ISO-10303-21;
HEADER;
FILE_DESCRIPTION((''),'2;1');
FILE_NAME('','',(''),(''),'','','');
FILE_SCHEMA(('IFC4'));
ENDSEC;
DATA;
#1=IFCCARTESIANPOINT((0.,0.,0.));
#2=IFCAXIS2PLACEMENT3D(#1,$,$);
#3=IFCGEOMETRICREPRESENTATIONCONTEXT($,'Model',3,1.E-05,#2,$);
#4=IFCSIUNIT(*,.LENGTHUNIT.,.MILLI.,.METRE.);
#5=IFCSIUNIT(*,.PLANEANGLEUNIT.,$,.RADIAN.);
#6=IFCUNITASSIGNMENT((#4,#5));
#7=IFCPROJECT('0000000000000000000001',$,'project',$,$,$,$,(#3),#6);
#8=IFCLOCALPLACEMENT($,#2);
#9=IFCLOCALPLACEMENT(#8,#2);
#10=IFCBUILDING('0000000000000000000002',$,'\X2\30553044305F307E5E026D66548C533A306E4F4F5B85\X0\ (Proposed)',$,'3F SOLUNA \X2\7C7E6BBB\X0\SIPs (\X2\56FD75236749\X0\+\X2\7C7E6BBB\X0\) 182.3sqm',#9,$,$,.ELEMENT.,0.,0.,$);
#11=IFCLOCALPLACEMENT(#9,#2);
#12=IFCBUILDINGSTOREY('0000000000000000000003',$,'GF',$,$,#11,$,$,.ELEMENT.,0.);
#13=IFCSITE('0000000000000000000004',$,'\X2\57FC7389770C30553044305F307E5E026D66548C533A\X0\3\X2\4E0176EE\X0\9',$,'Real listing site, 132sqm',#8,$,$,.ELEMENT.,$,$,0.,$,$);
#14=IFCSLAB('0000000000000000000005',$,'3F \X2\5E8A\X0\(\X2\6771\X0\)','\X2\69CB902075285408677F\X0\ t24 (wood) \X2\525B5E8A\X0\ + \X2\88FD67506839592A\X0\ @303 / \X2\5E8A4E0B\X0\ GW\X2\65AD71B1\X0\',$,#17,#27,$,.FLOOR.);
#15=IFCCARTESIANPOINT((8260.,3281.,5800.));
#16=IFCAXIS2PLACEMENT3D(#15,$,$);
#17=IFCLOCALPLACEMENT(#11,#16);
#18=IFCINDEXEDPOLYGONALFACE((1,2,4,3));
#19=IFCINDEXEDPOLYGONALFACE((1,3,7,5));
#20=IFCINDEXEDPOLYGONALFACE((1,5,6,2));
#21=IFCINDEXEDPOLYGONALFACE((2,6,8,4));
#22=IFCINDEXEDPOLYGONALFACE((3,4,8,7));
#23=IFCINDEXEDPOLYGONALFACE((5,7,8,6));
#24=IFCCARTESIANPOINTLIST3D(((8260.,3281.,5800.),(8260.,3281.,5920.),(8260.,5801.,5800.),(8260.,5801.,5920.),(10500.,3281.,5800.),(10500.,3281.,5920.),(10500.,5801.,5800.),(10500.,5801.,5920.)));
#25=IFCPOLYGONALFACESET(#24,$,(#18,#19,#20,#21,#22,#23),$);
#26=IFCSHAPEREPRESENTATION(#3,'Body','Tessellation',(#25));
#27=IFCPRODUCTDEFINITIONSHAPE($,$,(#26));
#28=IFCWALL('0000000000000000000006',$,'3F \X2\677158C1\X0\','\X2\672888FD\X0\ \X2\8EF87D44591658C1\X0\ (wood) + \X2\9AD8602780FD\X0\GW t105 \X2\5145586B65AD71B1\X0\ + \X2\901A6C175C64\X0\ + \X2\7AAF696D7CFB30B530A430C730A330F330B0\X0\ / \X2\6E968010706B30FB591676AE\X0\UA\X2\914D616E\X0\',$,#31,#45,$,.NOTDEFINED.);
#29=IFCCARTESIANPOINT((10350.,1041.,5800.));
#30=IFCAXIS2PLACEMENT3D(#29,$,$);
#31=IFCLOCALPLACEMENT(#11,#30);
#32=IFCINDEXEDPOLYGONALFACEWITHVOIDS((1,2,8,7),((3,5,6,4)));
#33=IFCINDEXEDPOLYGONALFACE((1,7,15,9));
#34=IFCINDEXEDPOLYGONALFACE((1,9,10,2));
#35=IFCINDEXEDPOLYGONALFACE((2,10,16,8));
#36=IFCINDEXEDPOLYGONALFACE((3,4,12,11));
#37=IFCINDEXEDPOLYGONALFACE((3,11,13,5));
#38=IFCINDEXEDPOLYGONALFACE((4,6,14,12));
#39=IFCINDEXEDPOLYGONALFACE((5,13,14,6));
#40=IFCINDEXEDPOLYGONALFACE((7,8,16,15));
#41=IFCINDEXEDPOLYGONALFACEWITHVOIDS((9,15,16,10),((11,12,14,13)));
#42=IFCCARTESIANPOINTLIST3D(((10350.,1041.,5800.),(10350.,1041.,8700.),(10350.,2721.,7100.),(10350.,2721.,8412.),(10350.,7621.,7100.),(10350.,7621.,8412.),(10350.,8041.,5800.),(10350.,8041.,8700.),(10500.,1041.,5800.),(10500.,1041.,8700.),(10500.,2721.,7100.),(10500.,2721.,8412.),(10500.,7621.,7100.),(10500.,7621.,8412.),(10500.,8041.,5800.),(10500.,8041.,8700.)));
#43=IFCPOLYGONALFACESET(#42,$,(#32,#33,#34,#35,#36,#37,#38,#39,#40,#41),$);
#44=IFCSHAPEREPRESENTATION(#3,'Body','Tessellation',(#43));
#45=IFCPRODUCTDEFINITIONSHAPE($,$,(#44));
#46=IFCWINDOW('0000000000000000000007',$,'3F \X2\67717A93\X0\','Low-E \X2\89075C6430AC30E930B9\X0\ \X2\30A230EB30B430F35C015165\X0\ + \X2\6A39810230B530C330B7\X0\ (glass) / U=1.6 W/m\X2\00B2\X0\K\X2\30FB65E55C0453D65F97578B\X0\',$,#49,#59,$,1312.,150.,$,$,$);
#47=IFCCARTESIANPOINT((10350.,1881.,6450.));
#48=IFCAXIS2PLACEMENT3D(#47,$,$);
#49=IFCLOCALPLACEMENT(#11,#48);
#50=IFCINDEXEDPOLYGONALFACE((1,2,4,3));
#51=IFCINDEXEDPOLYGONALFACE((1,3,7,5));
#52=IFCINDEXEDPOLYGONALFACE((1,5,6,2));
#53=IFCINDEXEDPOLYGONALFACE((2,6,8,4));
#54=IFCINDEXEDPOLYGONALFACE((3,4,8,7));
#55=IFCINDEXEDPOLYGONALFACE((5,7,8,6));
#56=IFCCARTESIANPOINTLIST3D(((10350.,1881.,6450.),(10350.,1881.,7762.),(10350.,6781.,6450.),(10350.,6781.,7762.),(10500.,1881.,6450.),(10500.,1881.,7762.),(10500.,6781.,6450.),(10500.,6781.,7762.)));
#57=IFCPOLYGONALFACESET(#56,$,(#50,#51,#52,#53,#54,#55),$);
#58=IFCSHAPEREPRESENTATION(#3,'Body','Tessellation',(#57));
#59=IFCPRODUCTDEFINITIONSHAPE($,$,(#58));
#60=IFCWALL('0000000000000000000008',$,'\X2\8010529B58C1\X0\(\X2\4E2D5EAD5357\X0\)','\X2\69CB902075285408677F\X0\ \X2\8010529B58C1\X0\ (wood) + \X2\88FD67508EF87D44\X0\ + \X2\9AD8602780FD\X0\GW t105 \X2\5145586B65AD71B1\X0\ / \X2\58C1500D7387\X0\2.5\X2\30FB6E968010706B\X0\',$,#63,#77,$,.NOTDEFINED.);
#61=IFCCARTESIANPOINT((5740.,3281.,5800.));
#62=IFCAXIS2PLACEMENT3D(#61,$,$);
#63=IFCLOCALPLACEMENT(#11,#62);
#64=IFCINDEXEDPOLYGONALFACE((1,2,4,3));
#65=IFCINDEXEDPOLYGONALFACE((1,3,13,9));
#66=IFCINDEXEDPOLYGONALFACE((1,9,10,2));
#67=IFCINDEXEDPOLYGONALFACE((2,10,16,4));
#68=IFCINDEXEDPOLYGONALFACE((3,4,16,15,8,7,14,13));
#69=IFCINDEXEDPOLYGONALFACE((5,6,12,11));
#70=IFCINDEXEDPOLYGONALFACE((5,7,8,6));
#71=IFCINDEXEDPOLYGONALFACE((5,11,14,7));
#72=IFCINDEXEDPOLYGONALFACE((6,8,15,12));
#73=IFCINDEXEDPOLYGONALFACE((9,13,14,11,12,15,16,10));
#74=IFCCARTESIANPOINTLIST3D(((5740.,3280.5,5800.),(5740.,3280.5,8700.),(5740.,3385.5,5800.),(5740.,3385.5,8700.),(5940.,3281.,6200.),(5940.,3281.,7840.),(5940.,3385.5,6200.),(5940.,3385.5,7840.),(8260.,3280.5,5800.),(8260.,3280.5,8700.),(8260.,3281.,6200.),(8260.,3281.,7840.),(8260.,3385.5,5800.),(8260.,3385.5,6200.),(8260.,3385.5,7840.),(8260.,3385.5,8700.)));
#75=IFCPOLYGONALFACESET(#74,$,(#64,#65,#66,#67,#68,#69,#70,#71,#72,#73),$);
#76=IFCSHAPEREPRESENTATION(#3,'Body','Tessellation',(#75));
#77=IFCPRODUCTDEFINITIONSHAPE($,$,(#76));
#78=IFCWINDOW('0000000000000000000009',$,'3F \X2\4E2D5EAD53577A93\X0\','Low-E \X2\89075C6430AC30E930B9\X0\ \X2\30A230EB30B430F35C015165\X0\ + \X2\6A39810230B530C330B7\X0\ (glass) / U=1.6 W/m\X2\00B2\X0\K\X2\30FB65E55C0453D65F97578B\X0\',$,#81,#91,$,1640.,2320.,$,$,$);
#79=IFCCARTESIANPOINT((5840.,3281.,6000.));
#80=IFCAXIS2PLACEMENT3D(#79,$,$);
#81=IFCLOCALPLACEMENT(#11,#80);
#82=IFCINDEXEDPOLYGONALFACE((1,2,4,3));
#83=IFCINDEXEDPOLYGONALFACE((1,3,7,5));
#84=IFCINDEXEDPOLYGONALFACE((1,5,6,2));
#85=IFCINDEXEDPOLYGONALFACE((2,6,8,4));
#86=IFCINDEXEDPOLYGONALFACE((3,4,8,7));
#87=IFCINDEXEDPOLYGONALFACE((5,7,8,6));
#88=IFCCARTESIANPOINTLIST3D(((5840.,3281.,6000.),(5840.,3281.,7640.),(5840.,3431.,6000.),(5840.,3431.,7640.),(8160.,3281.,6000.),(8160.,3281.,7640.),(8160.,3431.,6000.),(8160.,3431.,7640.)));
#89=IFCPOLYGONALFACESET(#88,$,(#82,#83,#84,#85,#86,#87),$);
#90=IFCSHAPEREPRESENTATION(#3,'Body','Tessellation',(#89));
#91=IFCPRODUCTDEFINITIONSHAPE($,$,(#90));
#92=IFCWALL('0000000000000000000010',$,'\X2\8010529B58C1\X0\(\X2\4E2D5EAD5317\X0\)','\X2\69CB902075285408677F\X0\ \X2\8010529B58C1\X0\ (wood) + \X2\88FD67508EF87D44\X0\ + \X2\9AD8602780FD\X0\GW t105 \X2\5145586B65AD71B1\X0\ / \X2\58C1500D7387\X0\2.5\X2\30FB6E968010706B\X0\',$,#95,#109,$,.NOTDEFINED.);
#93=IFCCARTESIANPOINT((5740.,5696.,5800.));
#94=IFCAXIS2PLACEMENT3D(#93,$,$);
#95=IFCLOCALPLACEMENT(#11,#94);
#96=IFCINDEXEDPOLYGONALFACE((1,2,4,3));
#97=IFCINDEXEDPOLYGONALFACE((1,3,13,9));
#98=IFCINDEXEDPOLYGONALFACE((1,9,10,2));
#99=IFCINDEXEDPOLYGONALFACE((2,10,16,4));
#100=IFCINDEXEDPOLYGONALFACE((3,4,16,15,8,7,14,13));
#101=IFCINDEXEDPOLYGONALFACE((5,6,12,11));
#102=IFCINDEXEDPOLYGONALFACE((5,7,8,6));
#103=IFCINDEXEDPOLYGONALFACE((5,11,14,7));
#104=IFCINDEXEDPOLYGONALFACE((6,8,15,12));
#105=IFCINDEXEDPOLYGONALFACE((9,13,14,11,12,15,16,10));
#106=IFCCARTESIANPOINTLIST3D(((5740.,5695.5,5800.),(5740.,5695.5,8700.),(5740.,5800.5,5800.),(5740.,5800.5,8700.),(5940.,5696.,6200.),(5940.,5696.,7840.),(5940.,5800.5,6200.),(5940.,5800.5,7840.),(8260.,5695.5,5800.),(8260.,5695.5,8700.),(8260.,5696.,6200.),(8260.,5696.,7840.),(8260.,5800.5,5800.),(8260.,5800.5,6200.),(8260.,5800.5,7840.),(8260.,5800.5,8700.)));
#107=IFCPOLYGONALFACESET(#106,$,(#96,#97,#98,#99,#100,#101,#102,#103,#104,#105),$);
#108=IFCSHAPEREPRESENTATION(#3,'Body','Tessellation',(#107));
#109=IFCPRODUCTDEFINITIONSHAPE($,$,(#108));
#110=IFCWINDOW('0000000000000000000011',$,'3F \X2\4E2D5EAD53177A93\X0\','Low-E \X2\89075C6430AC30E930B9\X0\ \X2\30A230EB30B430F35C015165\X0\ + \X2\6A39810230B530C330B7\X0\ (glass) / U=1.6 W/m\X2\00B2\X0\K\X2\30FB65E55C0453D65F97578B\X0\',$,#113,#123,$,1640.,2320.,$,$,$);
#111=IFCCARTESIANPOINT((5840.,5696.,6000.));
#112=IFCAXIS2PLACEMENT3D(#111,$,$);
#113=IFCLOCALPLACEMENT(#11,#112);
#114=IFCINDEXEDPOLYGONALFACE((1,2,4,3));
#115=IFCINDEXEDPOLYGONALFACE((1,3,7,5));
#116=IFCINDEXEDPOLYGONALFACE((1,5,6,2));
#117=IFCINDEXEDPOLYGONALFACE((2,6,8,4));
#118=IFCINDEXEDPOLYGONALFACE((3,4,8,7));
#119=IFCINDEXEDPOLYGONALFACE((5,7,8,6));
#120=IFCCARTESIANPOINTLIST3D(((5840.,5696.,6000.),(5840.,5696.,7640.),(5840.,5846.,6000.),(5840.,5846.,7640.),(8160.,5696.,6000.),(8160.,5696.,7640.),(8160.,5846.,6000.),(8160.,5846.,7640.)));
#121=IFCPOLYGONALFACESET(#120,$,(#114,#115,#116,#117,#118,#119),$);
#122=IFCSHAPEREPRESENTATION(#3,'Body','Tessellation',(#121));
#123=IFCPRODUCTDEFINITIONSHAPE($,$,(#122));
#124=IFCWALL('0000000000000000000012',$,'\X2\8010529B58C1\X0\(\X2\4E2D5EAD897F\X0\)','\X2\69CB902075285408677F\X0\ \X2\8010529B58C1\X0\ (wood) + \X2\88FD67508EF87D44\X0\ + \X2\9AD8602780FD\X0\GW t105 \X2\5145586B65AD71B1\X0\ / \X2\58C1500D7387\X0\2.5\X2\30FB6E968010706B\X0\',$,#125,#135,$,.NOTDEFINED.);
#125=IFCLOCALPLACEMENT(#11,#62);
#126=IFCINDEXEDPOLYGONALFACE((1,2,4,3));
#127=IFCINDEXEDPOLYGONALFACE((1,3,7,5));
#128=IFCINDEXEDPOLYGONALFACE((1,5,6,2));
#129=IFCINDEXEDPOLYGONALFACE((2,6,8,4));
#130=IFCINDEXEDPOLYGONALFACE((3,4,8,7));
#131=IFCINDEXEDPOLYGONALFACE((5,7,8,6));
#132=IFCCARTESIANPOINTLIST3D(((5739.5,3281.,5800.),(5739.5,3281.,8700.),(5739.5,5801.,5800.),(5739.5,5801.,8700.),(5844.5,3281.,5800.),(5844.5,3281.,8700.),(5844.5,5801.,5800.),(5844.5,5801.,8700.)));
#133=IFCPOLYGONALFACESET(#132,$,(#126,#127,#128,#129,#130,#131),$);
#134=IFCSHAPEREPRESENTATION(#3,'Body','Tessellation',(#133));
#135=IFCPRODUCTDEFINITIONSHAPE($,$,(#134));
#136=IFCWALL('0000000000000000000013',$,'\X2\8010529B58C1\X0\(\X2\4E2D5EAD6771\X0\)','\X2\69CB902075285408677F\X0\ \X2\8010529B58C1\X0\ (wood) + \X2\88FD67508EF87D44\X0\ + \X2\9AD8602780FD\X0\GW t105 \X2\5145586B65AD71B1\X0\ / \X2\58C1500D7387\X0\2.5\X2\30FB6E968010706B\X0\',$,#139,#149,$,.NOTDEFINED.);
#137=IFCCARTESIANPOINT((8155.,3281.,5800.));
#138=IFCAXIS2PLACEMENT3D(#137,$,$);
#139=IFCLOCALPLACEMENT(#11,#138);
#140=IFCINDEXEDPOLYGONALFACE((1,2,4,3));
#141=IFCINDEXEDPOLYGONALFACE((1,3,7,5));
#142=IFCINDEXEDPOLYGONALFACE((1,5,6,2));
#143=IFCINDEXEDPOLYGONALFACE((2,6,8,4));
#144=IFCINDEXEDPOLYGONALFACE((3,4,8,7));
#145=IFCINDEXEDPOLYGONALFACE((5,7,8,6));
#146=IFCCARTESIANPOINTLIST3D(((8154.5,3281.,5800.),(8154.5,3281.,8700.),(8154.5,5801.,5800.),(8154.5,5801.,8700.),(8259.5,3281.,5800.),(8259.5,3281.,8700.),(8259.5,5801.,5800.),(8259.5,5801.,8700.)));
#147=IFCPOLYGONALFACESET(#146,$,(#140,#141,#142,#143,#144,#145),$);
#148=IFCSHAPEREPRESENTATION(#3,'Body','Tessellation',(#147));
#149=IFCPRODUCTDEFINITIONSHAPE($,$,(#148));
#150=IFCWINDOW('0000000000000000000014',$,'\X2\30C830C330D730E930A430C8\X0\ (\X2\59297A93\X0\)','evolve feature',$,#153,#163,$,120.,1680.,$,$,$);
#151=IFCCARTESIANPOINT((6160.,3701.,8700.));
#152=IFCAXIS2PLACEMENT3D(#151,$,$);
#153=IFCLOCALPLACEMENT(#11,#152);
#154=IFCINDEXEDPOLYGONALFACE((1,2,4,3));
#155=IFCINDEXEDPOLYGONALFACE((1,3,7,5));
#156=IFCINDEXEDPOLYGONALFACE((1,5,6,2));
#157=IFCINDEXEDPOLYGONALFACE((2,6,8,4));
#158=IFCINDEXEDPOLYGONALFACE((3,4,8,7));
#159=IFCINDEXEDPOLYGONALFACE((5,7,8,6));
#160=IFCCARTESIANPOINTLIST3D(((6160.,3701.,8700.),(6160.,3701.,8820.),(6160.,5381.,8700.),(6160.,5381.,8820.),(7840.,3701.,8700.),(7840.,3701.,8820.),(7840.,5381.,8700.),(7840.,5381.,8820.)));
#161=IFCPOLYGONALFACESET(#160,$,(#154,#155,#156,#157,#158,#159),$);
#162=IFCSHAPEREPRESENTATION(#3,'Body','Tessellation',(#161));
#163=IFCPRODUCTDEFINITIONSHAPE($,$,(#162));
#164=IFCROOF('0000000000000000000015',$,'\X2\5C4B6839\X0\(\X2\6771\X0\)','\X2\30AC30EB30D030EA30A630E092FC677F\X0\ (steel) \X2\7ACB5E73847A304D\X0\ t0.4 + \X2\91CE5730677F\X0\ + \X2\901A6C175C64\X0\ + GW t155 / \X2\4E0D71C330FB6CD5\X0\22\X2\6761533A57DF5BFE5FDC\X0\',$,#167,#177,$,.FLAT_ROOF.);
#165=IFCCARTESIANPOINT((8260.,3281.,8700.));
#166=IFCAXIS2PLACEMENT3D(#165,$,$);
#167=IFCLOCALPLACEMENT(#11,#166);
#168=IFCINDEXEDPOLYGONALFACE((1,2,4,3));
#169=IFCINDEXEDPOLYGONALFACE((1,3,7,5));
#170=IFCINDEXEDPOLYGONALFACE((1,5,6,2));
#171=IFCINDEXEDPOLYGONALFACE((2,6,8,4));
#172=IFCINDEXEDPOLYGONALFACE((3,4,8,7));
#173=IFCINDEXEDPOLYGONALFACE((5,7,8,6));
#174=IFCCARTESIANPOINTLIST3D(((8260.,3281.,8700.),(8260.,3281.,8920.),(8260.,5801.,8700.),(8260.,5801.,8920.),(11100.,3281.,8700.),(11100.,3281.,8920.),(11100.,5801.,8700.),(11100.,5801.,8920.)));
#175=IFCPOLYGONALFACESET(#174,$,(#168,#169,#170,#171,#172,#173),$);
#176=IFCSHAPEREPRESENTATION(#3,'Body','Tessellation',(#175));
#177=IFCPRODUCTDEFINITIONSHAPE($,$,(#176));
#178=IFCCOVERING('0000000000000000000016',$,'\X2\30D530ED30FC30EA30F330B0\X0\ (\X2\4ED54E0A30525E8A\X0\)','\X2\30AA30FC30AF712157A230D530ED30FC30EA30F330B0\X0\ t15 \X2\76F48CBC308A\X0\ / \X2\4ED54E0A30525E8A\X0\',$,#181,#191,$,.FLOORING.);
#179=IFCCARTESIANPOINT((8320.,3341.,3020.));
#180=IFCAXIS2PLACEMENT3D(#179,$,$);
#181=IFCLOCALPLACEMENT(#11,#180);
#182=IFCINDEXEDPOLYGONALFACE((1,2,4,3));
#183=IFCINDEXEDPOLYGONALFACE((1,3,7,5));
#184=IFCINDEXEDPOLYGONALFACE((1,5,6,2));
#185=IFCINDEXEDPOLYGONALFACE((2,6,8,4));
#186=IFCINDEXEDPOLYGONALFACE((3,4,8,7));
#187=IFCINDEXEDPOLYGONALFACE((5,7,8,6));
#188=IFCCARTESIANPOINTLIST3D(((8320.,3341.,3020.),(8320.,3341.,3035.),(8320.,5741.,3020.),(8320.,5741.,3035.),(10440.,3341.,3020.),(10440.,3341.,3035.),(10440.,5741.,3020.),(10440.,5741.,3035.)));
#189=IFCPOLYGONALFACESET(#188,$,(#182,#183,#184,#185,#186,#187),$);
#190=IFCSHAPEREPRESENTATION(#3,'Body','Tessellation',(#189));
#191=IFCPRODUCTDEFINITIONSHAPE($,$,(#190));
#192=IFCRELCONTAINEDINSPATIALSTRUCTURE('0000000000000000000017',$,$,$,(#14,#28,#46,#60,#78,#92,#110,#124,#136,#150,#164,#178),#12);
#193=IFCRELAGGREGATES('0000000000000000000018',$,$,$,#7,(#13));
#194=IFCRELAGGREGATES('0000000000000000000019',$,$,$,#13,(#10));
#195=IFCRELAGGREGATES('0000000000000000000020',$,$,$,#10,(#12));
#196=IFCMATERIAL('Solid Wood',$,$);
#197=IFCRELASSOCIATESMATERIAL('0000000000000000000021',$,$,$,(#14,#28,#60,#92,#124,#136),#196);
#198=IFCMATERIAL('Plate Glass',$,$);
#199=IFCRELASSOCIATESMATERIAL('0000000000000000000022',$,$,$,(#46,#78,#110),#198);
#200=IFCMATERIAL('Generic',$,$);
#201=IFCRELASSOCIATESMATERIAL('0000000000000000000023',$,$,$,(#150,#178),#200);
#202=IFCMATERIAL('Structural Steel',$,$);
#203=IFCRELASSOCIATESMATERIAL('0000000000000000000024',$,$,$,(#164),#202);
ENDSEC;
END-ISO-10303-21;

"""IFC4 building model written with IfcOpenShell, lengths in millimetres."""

from ifc_helpers import new_model, si_unit, frame, frame_2d, origin, place, context, project, spatial, rectangle, extrude, material, element, fill, save


model = new_model("IFC4")

# Units and contexts
model_context = context("Model", 3, precision=1e-05, world=origin())
ifc_project = project(units=[si_unit("LENGTHUNIT", "METRE", prefix="MILLI"), si_unit("PLANEANGLEUNIT", "RADIAN")], contexts=[model_context])

# Site, building, storey
site_placement = place(None, origin())
site = spatial("IfcSite", under=ifc_project, at=site_placement, Name="埼玉県さいたま市浦和区3丁目9", ObjectType="Real listing site, 132sqm", CompositionType="ELEMENT", RefElevation=0.0)
building_placement = place(site_placement, origin())
building = spatial("IfcBuilding", under=site, at=building_placement, Name="さいたま市浦和区の住宅 (Proposed)", ObjectType="3F SOLUNA 籾殻SIPs (国産杉+籾殻) 182.3sqm", CompositionType="ELEMENT", ElevationOfRefHeight=0.0, ElevationOfTerrain=0.0)
storey_placement = place(building_placement, origin())
storey = spatial("IfcBuildingStorey", under=building, at=storey_placement, Name="GF", CompositionType="ELEMENT", Elevation=0.0)

# Slab
ifc_material_1 = material(Name="Solid Wood")
slab_placement = place(storey_placement, frame((8260.0, 3281.0, 5800.0)))
element("IfcSlab", 1, at=slab_placement, inside=storey, material=ifc_material_1, Name="3F 床(東)", Description="構造用合板 t24 (wood) 剛床 + 製材根太 @303 / 床下 GW断熱", PredefinedType="FLOOR", context=model_context, shape_type="SweptSolid", body=[
    extrude(rectangle(XDim=2240.0, YDim=2520.0, at=frame_2d((1120.0, 1260.0))), frame((8260.0, 3281.0, 5800.0)), (0.0, 0.0, 1.0), 120.0),
])

# Walls, openings, windows
wall_1_placement = place(storey_placement, frame((10350.0, 1041.0, 5800.0)))
wall_1 = element("IfcWall", 2, at=wall_1_placement, inside=storey, material=ifc_material_1, Name="3F 東壁", Description="木製 軸組外壁 (wood) + 高性能GW t105 充填断熱 + 通気層 + 窯業系サイディング / 準耐火・外皮UA配慮", PredefinedType="NOTDEFINED", context=model_context, shape_type="SweptSolid", body=[
    extrude(rectangle(XDim=150.0, YDim=7000.0, at=frame_2d((75.0, 3500.0))), frame((10350.0, 1041.0, 5800.0)), (0.0, 0.0, 1.0), 2900.0),
])
opening_1_placement = place(storey_placement, frame((10350.0, 1881.0, 6450.0)))
opening_1 = element("IfcOpeningElement", 3, at=opening_1_placement, cuts=wall_1, PredefinedType="NOTDEFINED", context=model_context, shape_type="SweptSolid", body=[
    extrude(rectangle(XDim=150.0, YDim=4900.0, at=frame_2d((75.0, 2450.0))), frame((10350.0, 1881.0, 6450.0)), (0.0, 0.0, 1.0), 1312.0),
])
ifc_material_2 = material(Name="Plate Glass")
window_1_placement = place(storey_placement, frame((10350.0, 1881.0, 6450.0)))
window_1 = element("IfcWindow", 4, at=window_1_placement, inside=storey, material=ifc_material_2, Name="3F 東窓", Description="Low-E 複層ガラス アルゴン封入 + 樹脂サッシ (glass) / U=1.6 W/m²K・日射取得型", OverallHeight=1312.0, OverallWidth=150.0, context=model_context, shape_type="SweptSolid", body=[
    extrude(rectangle(XDim=150.0, YDim=4900.0, at=frame_2d((75.0, 2450.0))), frame((10350.0, 1881.0, 6450.0)), (0.0, 0.0, 1.0), 1312.0),
])
fill(opening_1, window_1)
wall_2_placement = place(storey_placement, frame((5740.0, 3281.0, 5800.0)))
wall_2 = element("IfcWall", 5, at=wall_2_placement, inside=storey, material=ifc_material_1, Name="耐力壁(中庭南)", Description="構造用合板 耐力壁 (wood) + 製材軸組 + 高性能GW t105 充填断熱 / 壁倍率2.5・準耐火", PredefinedType="NOTDEFINED", context=model_context, shape_type="SweptSolid", body=[
    extrude(rectangle(XDim=2520.0, YDim=105.0, at=frame_2d((1260.0, 52.0))), frame((5740.0, 3281.0, 5800.0)), (0.0, 0.0, 1.0), 2900.0),
])
opening_2_placement = place(storey_placement, frame((5840.0, 3281.0, 6000.0)))
opening_2 = element("IfcOpeningElement", 6, at=opening_2_placement, cuts=wall_2, PredefinedType="NOTDEFINED", context=model_context, shape_type="SweptSolid", body=[
    extrude(rectangle(XDim=2320.0, YDim=150.0, at=frame_2d((1160.0, 75.0))), frame((5840.0, 3281.0, 6000.0)), (0.0, 0.0, 1.0), 1640.0),
])
window_2_placement = place(storey_placement, frame((5840.0, 3281.0, 6000.0)))
window_2 = element("IfcWindow", 7, at=window_2_placement, inside=storey, material=ifc_material_2, Name="3F 中庭南窓", Description="Low-E 複層ガラス アルゴン封入 + 樹脂サッシ (glass) / U=1.6 W/m²K・日射取得型", OverallHeight=1640.0, OverallWidth=2320.0, context=model_context, shape_type="SweptSolid", body=[
    extrude(rectangle(XDim=2320.0, YDim=150.0, at=frame_2d((1160.0, 75.0))), frame((5840.0, 3281.0, 6000.0)), (0.0, 0.0, 1.0), 1640.0),
])
fill(opening_2, window_2)
wall_3_placement = place(storey_placement, frame((5740.0, 5696.0, 5800.0)))
wall_3 = element("IfcWall", 8, at=wall_3_placement, inside=storey, material=ifc_material_1, Name="耐力壁(中庭北)", Description="構造用合板 耐力壁 (wood) + 製材軸組 + 高性能GW t105 充填断熱 / 壁倍率2.5・準耐火", PredefinedType="NOTDEFINED", context=model_context, shape_type="SweptSolid", body=[
    extrude(rectangle(XDim=2520.0, YDim=105.0, at=frame_2d((1260.0, 52.0))), frame((5740.0, 5696.0, 5800.0)), (0.0, 0.0, 1.0), 2900.0),
])
opening_3_placement = place(storey_placement, frame((5840.0, 5696.0, 6000.0)))
opening_3 = element("IfcOpeningElement", 9, at=opening_3_placement, cuts=wall_3, PredefinedType="NOTDEFINED", context=model_context, shape_type="SweptSolid", body=[
    extrude(rectangle(XDim=2320.0, YDim=150.0, at=frame_2d((1160.0, 75.0))), frame((5840.0, 5696.0, 6000.0)), (0.0, 0.0, 1.0), 1640.0),
])
window_3_placement = place(storey_placement, frame((5840.0, 5696.0, 6000.0)))
window_3 = element("IfcWindow", 10, at=window_3_placement, inside=storey, material=ifc_material_2, Name="3F 中庭北窓", Description="Low-E 複層ガラス アルゴン封入 + 樹脂サッシ (glass) / U=1.6 W/m²K・日射取得型", OverallHeight=1640.0, OverallWidth=2320.0, context=model_context, shape_type="SweptSolid", body=[
    extrude(rectangle(XDim=2320.0, YDim=150.0, at=frame_2d((1160.0, 75.0))), frame((5840.0, 5696.0, 6000.0)), (0.0, 0.0, 1.0), 1640.0),
])
fill(opening_3, window_3)

# Walls
wall_4_placement = place(storey_placement, frame((5740.0, 3281.0, 5800.0)))
element("IfcWall", 11, at=wall_4_placement, inside=storey, material=ifc_material_1, Name="耐力壁(中庭西)", Description="構造用合板 耐力壁 (wood) + 製材軸組 + 高性能GW t105 充填断熱 / 壁倍率2.5・準耐火", PredefinedType="NOTDEFINED", context=model_context, shape_type="SweptSolid", body=[
    extrude(rectangle(XDim=105.0, YDim=2520.0, at=frame_2d((52.0, 1260.0))), frame((5740.0, 3281.0, 5800.0)), (0.0, 0.0, 1.0), 2900.0),
])
wall_5_placement = place(storey_placement, frame((8155.0, 3281.0, 5800.0)))
element("IfcWall", 12, at=wall_5_placement, inside=storey, material=ifc_material_1, Name="耐力壁(中庭東)", Description="構造用合板 耐力壁 (wood) + 製材軸組 + 高性能GW t105 充填断熱 / 壁倍率2.5・準耐火", PredefinedType="NOTDEFINED", context=model_context, shape_type="SweptSolid", body=[
    extrude(rectangle(XDim=105.0, YDim=2520.0, at=frame_2d((52.0, 1260.0))), frame((8155.0, 3281.0, 5800.0)), (0.0, 0.0, 1.0), 2900.0),
])

# Window
ifc_material_3 = material(Name="Generic")
window_4_placement = place(storey_placement, frame((6160.0, 3701.0, 8700.0)))
element("IfcWindow", 13, at=window_4_placement, inside=storey, material=ifc_material_3, Name="トップライト (天窓)", Description="evolve feature", OverallHeight=120.0, OverallWidth=1680.0, context=model_context, shape_type="SweptSolid", body=[
    extrude(rectangle(XDim=1680.0, YDim=1680.0, at=frame_2d((840.0, 840.0))), frame((6160.0, 3701.0, 8700.0)), (0.0, 0.0, 1.0), 120.0),
])

# Roof
ifc_material_4 = material(Name="Structural Steel")
for number, where, name in (
    (14, (8260.0, 3281.0, 8700.0), "屋根(東)"),
):
    element("IfcRoof", number, at=place(storey_placement, frame(where)), inside=storey, material=ifc_material_4, Name=name, Description="ガルバリウム鋼板 (steel) 立平葺き t0.4 + 野地板 + 通気層 + GW t155 / 不燃・法22条区域対応", PredefinedType="FLAT_ROOF", context=model_context, shape_type="SweptSolid", body=[
        extrude(rectangle(XDim=2840.0, YDim=2520.0, at=frame_2d((1420.0, 1260.0))), frame((8260.0, 3281.0, 8700.0)), (0.0, 0.0, 1.0), 220.0),
    ])

# Covering
covering_1_placement = place(storey_placement, frame((8320.0, 3341.0, 3020.0)))
element("IfcCovering", 15, at=covering_1_placement, inside=storey, material=ifc_material_3, Name="フローリング (仕上げ床)", Description="オーク無垢フローリング t15 直貼り / 仕上げ床", PredefinedType="FLOORING", context=model_context, shape_type="SweptSolid", body=[
    extrude(rectangle(XDim=2120.0, YDim=2400.0, at=frame_2d((1060.0, 1200.0))), frame((8320.0, 3341.0, 3020.0)), (0.0, 0.0, 1.0), 15.0),
])

save(model, "model.ifc")
